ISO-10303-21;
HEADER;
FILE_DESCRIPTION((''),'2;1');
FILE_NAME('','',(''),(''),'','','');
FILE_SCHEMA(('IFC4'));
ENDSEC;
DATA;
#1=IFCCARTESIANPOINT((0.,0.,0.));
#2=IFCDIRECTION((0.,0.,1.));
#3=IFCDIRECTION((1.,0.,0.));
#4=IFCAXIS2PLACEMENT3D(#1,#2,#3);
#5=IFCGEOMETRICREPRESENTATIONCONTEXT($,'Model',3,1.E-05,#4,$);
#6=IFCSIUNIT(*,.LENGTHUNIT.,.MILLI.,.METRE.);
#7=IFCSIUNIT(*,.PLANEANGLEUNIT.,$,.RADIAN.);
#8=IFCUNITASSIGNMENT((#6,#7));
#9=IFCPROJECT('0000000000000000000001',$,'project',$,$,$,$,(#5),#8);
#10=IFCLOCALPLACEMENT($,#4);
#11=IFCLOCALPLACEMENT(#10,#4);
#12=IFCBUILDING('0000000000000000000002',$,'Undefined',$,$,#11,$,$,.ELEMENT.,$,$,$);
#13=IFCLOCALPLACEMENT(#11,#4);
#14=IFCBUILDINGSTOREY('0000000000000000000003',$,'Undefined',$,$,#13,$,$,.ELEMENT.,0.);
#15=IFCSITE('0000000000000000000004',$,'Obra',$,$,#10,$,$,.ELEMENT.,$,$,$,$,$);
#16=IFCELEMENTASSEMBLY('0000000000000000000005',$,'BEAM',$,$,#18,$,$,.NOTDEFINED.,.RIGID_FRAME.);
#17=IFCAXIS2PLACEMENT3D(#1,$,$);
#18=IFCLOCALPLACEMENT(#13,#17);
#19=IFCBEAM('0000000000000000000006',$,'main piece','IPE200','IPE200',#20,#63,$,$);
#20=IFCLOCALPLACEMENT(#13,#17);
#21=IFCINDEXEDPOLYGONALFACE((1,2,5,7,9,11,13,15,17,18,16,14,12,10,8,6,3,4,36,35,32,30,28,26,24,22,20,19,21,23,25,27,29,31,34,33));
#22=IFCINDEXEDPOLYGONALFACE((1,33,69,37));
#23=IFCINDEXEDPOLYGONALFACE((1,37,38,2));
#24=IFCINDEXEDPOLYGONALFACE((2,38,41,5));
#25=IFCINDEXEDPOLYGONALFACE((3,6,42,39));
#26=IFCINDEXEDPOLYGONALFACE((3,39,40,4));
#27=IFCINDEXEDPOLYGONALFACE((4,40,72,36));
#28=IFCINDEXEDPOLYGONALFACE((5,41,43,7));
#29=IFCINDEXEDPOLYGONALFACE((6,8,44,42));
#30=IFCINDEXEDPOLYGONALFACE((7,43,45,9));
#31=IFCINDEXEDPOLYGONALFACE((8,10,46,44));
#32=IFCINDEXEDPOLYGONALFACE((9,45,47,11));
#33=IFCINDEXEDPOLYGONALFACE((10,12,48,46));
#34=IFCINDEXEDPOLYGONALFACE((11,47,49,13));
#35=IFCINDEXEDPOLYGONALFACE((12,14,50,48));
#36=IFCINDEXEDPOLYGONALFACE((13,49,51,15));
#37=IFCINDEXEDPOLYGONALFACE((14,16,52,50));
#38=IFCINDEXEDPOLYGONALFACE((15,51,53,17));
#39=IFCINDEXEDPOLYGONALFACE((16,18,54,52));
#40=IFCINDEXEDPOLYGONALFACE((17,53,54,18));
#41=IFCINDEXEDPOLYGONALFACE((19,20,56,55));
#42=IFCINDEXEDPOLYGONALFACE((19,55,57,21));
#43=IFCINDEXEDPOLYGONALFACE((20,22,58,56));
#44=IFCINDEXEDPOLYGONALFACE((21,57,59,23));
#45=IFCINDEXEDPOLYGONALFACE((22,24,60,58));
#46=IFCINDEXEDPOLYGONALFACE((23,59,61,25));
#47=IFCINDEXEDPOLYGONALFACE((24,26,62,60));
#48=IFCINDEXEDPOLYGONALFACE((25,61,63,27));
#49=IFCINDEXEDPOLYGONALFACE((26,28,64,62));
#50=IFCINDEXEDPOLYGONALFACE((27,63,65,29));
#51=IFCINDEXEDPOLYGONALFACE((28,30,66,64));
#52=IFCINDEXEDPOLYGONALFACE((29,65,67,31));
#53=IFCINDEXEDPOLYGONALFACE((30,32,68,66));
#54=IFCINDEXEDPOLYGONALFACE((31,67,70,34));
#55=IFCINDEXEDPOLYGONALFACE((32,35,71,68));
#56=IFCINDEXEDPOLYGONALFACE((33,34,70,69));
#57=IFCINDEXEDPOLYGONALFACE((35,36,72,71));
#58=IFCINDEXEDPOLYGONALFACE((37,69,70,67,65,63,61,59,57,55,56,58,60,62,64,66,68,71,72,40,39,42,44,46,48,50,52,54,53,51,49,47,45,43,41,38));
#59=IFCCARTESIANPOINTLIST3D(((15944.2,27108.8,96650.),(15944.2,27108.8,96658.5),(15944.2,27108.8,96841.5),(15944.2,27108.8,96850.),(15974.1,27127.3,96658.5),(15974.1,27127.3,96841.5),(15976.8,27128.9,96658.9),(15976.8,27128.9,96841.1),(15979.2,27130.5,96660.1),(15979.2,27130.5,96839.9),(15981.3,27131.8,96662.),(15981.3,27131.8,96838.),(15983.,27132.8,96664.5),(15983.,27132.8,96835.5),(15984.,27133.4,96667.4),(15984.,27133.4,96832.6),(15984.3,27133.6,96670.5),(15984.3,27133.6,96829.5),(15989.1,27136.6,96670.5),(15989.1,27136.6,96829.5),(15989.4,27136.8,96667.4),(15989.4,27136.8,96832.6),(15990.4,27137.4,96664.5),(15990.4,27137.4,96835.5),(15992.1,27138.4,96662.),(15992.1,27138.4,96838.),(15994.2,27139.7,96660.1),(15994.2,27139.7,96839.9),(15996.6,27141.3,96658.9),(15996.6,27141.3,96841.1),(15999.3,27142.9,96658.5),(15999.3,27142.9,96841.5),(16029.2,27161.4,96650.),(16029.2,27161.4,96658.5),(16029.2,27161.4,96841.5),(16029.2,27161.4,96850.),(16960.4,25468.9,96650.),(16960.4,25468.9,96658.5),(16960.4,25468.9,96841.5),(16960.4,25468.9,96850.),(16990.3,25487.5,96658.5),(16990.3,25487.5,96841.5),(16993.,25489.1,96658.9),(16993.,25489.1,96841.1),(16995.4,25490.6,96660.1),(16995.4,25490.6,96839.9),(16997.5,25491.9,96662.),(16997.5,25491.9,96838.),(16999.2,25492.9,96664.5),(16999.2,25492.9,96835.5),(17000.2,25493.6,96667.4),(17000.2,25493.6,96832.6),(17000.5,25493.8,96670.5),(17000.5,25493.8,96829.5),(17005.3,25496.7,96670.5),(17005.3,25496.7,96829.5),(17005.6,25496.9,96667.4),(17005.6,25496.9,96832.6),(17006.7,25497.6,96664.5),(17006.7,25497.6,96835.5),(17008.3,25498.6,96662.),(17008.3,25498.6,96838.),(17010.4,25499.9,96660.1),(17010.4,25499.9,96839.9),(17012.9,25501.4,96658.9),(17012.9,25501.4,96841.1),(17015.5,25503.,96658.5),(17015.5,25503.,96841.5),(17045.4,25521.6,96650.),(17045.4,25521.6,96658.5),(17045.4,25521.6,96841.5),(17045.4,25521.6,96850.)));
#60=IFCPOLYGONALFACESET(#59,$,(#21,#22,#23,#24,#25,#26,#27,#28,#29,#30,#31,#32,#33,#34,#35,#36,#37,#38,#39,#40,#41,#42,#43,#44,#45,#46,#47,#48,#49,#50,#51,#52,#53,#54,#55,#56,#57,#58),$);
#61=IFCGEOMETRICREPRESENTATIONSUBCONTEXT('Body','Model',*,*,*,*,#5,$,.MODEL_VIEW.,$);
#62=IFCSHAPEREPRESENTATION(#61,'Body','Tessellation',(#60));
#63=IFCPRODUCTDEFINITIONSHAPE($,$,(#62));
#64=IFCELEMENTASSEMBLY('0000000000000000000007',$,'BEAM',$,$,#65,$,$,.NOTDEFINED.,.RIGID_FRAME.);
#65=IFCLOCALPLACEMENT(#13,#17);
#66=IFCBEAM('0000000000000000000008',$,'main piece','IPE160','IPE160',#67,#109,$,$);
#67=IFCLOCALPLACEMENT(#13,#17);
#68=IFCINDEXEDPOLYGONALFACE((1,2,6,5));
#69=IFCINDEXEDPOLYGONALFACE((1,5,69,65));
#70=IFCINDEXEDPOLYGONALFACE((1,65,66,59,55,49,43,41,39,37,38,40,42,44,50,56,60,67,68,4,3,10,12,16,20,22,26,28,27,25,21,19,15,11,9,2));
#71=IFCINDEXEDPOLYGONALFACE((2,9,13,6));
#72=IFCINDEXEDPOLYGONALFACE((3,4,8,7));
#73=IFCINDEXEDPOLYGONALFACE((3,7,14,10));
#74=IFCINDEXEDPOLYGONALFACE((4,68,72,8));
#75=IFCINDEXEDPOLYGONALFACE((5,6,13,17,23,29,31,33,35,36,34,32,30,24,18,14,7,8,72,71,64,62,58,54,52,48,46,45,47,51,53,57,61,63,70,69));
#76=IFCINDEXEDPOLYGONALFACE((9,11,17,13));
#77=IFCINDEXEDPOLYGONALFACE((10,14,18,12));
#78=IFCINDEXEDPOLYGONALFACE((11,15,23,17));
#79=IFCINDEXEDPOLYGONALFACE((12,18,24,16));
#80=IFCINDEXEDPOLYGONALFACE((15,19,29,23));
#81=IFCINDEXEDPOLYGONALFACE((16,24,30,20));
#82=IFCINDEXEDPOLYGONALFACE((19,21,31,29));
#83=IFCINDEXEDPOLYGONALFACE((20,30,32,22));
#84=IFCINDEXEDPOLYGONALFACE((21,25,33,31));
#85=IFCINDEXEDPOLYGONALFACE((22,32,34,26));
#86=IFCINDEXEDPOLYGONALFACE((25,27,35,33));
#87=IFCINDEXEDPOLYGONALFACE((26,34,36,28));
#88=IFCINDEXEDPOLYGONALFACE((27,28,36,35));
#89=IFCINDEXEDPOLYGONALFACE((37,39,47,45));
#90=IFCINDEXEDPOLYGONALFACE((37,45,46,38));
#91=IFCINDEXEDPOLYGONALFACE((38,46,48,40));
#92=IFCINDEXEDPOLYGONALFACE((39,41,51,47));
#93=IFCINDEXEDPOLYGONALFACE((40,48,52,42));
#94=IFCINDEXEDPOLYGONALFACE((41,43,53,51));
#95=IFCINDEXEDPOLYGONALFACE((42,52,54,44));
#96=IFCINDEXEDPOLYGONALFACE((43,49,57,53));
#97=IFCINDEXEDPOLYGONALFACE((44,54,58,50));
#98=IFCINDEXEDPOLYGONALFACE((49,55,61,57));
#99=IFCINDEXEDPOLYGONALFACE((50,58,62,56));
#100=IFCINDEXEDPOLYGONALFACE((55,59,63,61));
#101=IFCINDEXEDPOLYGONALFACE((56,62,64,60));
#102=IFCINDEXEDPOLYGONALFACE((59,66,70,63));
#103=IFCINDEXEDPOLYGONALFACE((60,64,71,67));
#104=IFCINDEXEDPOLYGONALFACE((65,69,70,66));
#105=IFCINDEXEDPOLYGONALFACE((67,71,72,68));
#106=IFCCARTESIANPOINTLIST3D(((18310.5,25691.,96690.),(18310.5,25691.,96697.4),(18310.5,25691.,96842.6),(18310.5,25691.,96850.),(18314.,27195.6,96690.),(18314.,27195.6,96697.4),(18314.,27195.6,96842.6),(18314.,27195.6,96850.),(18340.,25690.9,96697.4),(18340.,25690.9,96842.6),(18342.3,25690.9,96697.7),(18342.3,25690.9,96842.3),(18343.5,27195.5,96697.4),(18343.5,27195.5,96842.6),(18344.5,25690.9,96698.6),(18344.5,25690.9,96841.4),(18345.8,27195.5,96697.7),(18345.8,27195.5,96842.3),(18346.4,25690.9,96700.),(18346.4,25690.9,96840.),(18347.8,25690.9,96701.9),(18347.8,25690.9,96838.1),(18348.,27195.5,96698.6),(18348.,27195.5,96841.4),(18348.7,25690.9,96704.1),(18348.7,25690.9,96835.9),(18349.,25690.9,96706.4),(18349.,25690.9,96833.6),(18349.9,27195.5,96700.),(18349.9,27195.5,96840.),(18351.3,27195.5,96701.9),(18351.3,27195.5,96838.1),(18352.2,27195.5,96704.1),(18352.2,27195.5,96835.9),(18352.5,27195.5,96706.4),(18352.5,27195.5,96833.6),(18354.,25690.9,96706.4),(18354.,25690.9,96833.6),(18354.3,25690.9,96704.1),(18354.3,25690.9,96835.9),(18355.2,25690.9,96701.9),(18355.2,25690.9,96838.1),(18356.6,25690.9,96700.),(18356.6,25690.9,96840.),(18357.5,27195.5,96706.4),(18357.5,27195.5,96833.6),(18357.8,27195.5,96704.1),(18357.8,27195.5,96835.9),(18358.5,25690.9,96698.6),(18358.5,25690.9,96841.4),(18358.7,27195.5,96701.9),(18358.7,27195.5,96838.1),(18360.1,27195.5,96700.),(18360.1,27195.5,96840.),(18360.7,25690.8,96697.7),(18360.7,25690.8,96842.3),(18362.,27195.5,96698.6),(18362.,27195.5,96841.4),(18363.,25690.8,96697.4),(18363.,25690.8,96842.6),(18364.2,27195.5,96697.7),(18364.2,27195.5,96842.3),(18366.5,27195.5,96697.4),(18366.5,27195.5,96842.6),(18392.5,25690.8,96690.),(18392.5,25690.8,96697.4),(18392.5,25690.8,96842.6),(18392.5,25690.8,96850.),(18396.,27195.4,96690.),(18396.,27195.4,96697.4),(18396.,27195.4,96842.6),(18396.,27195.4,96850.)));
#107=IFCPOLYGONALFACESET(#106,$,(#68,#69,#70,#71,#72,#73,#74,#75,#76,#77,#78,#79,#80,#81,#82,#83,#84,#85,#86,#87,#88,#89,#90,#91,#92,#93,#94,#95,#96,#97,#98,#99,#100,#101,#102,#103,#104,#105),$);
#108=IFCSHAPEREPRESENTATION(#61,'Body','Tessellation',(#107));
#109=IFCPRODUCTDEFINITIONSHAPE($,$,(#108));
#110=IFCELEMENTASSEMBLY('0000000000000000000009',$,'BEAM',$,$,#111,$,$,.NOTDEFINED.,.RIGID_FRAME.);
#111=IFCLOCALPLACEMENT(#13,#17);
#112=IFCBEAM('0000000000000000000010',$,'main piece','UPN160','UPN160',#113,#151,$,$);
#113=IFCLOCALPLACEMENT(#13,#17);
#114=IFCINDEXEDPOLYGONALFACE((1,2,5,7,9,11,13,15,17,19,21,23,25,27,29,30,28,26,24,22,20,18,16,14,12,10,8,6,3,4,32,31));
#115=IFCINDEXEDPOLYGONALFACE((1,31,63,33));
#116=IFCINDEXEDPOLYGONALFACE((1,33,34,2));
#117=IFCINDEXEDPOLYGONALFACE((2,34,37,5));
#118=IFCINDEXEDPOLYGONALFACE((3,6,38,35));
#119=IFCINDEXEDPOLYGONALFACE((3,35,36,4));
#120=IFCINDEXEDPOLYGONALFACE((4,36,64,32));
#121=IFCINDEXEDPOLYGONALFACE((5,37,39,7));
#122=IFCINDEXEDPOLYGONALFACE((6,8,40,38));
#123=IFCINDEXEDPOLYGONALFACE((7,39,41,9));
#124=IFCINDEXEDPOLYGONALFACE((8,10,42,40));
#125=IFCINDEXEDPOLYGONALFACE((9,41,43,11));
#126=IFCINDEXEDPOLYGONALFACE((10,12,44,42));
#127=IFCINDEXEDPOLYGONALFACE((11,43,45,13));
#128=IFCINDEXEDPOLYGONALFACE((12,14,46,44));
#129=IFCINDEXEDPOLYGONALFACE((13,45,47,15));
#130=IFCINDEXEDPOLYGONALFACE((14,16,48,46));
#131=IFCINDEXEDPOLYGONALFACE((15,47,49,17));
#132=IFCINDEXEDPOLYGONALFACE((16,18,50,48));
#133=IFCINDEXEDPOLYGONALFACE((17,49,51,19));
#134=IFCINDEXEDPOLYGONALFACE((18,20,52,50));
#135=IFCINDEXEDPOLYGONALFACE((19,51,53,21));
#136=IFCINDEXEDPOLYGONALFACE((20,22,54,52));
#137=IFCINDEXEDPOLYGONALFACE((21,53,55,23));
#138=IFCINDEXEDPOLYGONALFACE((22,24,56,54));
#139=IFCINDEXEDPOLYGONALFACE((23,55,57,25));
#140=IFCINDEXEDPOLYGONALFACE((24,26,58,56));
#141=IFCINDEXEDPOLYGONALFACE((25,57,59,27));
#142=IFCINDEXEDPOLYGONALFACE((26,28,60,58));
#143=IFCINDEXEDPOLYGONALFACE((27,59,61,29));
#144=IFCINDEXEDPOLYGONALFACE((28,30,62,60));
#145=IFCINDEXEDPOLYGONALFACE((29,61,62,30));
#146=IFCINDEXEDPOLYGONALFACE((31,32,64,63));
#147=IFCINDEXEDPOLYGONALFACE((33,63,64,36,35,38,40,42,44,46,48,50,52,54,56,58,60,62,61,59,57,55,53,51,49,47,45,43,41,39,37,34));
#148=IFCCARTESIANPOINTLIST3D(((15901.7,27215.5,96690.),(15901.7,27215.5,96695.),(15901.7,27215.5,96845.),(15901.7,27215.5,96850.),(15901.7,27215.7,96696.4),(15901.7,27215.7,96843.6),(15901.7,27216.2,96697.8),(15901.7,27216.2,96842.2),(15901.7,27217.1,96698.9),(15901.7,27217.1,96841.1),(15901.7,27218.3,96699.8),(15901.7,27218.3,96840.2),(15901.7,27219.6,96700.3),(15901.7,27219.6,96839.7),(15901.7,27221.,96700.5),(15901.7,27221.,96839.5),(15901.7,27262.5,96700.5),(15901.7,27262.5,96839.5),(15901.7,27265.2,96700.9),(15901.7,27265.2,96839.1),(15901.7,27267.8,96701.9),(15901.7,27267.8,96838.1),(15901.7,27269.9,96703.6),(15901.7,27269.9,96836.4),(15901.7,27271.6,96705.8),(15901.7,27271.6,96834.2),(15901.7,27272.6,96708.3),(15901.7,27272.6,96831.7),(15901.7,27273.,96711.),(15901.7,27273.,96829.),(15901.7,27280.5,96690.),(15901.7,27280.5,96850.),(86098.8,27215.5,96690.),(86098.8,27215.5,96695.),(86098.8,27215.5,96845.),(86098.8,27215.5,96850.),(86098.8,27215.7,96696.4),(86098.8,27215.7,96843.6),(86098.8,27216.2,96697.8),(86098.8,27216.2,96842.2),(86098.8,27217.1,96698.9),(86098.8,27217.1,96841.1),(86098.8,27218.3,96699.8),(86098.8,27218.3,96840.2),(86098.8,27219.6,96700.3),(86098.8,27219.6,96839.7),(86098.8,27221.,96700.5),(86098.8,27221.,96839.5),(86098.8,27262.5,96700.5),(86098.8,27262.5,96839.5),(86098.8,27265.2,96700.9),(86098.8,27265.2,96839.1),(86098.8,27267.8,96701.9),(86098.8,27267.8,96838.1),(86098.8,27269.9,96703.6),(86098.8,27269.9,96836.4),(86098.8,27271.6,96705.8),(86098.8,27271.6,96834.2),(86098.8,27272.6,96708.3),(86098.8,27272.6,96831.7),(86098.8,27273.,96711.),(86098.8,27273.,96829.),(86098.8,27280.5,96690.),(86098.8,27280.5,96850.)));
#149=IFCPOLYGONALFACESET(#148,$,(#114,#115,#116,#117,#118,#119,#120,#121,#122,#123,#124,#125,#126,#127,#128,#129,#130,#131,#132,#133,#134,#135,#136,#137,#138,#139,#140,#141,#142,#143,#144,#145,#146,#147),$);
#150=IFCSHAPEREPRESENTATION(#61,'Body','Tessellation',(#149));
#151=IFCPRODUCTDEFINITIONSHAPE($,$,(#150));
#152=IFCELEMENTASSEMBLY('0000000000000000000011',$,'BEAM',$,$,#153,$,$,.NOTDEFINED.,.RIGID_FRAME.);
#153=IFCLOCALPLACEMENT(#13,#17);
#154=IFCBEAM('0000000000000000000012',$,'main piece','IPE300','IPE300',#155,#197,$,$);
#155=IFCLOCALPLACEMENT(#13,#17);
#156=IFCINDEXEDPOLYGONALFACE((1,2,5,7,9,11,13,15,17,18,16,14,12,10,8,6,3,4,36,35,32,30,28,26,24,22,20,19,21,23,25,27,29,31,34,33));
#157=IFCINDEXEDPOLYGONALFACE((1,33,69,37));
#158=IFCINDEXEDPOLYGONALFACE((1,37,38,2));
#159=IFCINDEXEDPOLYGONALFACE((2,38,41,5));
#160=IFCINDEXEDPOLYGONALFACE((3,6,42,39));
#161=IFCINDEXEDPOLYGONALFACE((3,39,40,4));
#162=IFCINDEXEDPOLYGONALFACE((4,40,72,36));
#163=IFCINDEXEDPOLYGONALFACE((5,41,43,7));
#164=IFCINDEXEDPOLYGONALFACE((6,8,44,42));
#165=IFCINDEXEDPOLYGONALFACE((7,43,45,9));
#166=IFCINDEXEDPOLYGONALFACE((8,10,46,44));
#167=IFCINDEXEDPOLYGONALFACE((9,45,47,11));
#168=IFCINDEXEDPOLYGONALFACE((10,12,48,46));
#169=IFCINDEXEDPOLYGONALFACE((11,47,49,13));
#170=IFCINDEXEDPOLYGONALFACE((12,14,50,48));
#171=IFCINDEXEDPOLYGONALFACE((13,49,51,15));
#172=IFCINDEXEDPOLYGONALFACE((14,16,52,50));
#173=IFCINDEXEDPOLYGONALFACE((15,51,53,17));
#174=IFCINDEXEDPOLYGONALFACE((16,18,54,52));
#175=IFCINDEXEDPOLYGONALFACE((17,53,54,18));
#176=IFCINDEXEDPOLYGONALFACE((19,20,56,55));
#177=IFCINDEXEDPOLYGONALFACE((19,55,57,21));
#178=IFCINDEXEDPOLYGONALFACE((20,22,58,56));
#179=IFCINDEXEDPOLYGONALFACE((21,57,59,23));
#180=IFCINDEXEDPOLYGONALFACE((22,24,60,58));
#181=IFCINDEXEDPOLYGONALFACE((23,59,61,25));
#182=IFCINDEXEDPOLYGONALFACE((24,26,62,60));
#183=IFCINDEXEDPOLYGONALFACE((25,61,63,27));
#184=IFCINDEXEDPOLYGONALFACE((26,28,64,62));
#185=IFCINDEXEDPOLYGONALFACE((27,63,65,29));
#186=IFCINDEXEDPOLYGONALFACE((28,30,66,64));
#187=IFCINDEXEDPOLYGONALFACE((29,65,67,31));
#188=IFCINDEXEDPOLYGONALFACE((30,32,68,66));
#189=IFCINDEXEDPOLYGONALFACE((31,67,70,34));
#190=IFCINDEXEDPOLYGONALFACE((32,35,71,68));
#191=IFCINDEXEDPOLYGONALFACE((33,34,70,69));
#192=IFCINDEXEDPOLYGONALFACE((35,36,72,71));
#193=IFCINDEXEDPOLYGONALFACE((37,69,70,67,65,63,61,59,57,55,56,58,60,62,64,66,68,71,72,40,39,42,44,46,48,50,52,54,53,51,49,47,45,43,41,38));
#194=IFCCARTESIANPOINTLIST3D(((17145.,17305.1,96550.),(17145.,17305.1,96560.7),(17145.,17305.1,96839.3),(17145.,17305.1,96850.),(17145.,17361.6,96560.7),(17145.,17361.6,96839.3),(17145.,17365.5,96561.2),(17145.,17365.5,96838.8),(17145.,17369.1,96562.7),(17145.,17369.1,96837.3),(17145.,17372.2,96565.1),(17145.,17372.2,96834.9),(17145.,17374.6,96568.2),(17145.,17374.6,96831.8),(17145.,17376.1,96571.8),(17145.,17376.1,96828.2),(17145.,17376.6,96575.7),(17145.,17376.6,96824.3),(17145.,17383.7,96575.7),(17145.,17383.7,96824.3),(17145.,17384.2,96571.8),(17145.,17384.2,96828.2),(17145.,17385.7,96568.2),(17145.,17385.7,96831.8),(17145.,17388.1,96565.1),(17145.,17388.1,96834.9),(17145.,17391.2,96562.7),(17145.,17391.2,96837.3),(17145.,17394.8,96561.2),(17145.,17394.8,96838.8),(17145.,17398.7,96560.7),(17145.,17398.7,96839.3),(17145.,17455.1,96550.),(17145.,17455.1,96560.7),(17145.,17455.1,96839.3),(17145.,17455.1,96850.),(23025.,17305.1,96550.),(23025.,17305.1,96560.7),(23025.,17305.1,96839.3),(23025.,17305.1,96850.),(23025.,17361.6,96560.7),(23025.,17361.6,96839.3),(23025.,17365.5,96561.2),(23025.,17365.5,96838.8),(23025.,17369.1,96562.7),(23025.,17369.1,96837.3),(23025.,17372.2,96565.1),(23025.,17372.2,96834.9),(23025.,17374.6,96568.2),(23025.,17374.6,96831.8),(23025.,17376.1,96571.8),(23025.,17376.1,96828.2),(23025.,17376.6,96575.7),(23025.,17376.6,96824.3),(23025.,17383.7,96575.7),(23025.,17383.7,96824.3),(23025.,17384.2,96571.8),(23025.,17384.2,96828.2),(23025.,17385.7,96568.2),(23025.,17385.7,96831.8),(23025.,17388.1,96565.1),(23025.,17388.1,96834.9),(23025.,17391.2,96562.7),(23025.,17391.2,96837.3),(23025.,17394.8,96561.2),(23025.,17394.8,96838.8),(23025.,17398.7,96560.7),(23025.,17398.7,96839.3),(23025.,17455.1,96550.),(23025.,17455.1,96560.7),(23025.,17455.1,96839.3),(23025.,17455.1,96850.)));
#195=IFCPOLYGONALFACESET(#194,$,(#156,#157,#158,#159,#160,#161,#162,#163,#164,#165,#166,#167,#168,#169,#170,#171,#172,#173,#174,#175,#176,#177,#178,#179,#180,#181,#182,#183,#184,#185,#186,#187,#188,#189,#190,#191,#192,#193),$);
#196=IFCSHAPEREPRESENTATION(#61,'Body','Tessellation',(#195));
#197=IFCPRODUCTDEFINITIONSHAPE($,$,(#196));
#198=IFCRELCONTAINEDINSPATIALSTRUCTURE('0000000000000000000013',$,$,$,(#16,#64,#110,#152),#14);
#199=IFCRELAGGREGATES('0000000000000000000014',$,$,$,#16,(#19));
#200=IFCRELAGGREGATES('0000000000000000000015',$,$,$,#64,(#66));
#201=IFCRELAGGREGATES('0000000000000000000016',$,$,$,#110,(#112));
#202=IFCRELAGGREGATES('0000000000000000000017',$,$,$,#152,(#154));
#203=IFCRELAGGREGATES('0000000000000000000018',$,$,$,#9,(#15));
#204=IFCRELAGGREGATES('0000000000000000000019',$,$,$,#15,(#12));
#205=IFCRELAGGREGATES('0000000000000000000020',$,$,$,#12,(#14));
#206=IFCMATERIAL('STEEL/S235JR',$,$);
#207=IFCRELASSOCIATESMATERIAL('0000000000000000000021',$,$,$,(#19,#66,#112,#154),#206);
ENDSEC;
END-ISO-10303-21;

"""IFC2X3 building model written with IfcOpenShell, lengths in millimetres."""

from ifc_helpers import new_model, si_unit, frame, origin_with_axes, origin_2d_with_axis, place, context, subcontext, project, spatial, i_section, u_section, extrude, material, element, aggregate, save


model = new_model("IFC2X3")

# Units and contexts
model_context = context("Model", 3, precision=1e-05, world=origin_with_axes())
body_context = subcontext(model_context, "Body", "Model", "MODEL_VIEW")
ifc_project = project(units=[si_unit("LENGTHUNIT", "METRE", prefix="MILLI"), si_unit("PLANEANGLEUNIT", "RADIAN")], contexts=[model_context])

# Site, building, storey
site_placement = place(None, origin_with_axes())
site = spatial("IfcSite", under=ifc_project, at=site_placement, Name="Obra", CompositionType="ELEMENT")
building_placement = place(site_placement, origin_with_axes())
building = spatial("IfcBuilding", under=site, at=building_placement, Name="Undefined", CompositionType="ELEMENT")
storey_placement = place(building_placement, origin_with_axes())
storey = spatial("IfcBuildingStorey", under=building, at=storey_placement, Name="Undefined", CompositionType="ELEMENT", Elevation=0.0)

# Element assemblies, beams
ifc_material = material(Name="STEEL/S235JR")
assembly_1_placement = place(storey_placement, origin_with_axes())
assembly_1 = element("IfcElementAssembly", 1, at=assembly_1_placement, inside=storey, Name="BEAM", AssemblyPlace="NOTDEFINED", PredefinedType="RIGID_FRAME")
beam_1_placement = place(assembly_1_placement, frame((17002.9, 25495.3, 96750.0), z_axis=(0.0, 0.0, 1.0), x_axis=(-0.526756, 0.850017, 0.0)))
beam_1 = element("IfcBeam", 2, at=beam_1_placement, material=ifc_material, Name="main piece", Description="IPE200", ObjectType="IPE200", context=body_context, shape_type="SweptSolid", body=[
    extrude(i_section(OverallWidth=100.0, OverallDepth=200.0, WebThickness=5.6, FlangeThickness=8.5, FilletRadius=12.0, at=origin_2d_with_axis()), frame((1929.2, 0.0, 0.0), z_axis=(-1.0, 0.0, 0.0), x_axis=(0.0, -1.0, 0.0)), (0.0, 0.0, 1.0), 1929.2),
])
aggregate(assembly_1, [beam_1])
assembly_2_placement = place(storey_placement, origin_with_axes())
assembly_2 = element("IfcElementAssembly", 3, at=assembly_2_placement, inside=storey, Name="BEAM", AssemblyPlace="NOTDEFINED", PredefinedType="RIGID_FRAME")
beam_2_placement = place(assembly_2_placement, frame((18351.5, 25690.9, 96770.0), z_axis=(0.0, 0.0, 1.0), x_axis=(0.002325, 0.999997, 0.0)))
beam_2 = element("IfcBeam", 4, at=beam_2_placement, material=ifc_material, Name="main piece", Description="IPE160", ObjectType="IPE160", context=body_context, shape_type="SweptSolid", body=[
    extrude(i_section(OverallWidth=82.0, OverallDepth=160.0, WebThickness=5.0, FlangeThickness=7.4, FilletRadius=9.0, at=origin_2d_with_axis()), frame((1504.6, 0.0, 0.0), z_axis=(-1.0, 0.0, 0.0), x_axis=(0.0, -1.0, 0.0)), (0.0, 0.0, 1.0), 1504.6),
])
aggregate(assembly_2, [beam_2])
assembly_3_placement = place(storey_placement, origin_with_axes())
assembly_3 = element("IfcElementAssembly", 5, at=assembly_3_placement, inside=storey, Name="BEAM", AssemblyPlace="NOTDEFINED", PredefinedType="RIGID_FRAME")
beam_3_placement = place(assembly_3_placement, frame((15901.7, 27248.0, 96770.0), z_axis=(0.0, 0.0, 1.0), x_axis=(1.0, 0.0, 0.0)))
beam_3 = element("IfcBeam", 6, at=beam_3_placement, material=ifc_material, Name="main piece", Description="UPN160", ObjectType="UPN160", context=body_context, shape_type="SweptSolid", body=[
    extrude(u_section(Depth=160.0, FlangeWidth=65.0, WebThickness=7.5, FlangeThickness=10.5, FilletRadius=10.5, EdgeRadius=5.5, at=origin_2d_with_axis()), frame((70197.1, 0.0, 0.0), z_axis=(-1.0, 0.0, 0.0), x_axis=(0.0, -1.0, 0.0)), (0.0, 0.0, 1.0), 70197.1),
])
aggregate(assembly_3, [beam_3])
assembly_4_placement = place(storey_placement, origin_with_axes())
assembly_4 = element("IfcElementAssembly", 7, at=assembly_4_placement, inside=storey, Name="BEAM", AssemblyPlace="NOTDEFINED", PredefinedType="RIGID_FRAME")
beam_4_placement = place(assembly_4_placement, frame((17145.0, 17380.1, 96700.0), z_axis=(0.0, 0.0, 1.0), x_axis=(1.0, 0.0, 0.0)))
beam_4 = element("IfcBeam", 8, at=beam_4_placement, material=ifc_material, Name="main piece", Description="IPE300", ObjectType="IPE300", context=body_context, shape_type="SweptSolid", body=[
    extrude(i_section(OverallWidth=150.0, OverallDepth=300.0, WebThickness=7.1, FlangeThickness=10.7, FilletRadius=15.0, at=origin_2d_with_axis()), frame((5880.0, 0.0, 0.0), z_axis=(-1.0, 0.0, 0.0), x_axis=(0.0, -1.0, 0.0)), (0.0, 0.0, 1.0), 5880.0),
])
aggregate(assembly_4, [beam_4])

save(model, "model.ifc")
